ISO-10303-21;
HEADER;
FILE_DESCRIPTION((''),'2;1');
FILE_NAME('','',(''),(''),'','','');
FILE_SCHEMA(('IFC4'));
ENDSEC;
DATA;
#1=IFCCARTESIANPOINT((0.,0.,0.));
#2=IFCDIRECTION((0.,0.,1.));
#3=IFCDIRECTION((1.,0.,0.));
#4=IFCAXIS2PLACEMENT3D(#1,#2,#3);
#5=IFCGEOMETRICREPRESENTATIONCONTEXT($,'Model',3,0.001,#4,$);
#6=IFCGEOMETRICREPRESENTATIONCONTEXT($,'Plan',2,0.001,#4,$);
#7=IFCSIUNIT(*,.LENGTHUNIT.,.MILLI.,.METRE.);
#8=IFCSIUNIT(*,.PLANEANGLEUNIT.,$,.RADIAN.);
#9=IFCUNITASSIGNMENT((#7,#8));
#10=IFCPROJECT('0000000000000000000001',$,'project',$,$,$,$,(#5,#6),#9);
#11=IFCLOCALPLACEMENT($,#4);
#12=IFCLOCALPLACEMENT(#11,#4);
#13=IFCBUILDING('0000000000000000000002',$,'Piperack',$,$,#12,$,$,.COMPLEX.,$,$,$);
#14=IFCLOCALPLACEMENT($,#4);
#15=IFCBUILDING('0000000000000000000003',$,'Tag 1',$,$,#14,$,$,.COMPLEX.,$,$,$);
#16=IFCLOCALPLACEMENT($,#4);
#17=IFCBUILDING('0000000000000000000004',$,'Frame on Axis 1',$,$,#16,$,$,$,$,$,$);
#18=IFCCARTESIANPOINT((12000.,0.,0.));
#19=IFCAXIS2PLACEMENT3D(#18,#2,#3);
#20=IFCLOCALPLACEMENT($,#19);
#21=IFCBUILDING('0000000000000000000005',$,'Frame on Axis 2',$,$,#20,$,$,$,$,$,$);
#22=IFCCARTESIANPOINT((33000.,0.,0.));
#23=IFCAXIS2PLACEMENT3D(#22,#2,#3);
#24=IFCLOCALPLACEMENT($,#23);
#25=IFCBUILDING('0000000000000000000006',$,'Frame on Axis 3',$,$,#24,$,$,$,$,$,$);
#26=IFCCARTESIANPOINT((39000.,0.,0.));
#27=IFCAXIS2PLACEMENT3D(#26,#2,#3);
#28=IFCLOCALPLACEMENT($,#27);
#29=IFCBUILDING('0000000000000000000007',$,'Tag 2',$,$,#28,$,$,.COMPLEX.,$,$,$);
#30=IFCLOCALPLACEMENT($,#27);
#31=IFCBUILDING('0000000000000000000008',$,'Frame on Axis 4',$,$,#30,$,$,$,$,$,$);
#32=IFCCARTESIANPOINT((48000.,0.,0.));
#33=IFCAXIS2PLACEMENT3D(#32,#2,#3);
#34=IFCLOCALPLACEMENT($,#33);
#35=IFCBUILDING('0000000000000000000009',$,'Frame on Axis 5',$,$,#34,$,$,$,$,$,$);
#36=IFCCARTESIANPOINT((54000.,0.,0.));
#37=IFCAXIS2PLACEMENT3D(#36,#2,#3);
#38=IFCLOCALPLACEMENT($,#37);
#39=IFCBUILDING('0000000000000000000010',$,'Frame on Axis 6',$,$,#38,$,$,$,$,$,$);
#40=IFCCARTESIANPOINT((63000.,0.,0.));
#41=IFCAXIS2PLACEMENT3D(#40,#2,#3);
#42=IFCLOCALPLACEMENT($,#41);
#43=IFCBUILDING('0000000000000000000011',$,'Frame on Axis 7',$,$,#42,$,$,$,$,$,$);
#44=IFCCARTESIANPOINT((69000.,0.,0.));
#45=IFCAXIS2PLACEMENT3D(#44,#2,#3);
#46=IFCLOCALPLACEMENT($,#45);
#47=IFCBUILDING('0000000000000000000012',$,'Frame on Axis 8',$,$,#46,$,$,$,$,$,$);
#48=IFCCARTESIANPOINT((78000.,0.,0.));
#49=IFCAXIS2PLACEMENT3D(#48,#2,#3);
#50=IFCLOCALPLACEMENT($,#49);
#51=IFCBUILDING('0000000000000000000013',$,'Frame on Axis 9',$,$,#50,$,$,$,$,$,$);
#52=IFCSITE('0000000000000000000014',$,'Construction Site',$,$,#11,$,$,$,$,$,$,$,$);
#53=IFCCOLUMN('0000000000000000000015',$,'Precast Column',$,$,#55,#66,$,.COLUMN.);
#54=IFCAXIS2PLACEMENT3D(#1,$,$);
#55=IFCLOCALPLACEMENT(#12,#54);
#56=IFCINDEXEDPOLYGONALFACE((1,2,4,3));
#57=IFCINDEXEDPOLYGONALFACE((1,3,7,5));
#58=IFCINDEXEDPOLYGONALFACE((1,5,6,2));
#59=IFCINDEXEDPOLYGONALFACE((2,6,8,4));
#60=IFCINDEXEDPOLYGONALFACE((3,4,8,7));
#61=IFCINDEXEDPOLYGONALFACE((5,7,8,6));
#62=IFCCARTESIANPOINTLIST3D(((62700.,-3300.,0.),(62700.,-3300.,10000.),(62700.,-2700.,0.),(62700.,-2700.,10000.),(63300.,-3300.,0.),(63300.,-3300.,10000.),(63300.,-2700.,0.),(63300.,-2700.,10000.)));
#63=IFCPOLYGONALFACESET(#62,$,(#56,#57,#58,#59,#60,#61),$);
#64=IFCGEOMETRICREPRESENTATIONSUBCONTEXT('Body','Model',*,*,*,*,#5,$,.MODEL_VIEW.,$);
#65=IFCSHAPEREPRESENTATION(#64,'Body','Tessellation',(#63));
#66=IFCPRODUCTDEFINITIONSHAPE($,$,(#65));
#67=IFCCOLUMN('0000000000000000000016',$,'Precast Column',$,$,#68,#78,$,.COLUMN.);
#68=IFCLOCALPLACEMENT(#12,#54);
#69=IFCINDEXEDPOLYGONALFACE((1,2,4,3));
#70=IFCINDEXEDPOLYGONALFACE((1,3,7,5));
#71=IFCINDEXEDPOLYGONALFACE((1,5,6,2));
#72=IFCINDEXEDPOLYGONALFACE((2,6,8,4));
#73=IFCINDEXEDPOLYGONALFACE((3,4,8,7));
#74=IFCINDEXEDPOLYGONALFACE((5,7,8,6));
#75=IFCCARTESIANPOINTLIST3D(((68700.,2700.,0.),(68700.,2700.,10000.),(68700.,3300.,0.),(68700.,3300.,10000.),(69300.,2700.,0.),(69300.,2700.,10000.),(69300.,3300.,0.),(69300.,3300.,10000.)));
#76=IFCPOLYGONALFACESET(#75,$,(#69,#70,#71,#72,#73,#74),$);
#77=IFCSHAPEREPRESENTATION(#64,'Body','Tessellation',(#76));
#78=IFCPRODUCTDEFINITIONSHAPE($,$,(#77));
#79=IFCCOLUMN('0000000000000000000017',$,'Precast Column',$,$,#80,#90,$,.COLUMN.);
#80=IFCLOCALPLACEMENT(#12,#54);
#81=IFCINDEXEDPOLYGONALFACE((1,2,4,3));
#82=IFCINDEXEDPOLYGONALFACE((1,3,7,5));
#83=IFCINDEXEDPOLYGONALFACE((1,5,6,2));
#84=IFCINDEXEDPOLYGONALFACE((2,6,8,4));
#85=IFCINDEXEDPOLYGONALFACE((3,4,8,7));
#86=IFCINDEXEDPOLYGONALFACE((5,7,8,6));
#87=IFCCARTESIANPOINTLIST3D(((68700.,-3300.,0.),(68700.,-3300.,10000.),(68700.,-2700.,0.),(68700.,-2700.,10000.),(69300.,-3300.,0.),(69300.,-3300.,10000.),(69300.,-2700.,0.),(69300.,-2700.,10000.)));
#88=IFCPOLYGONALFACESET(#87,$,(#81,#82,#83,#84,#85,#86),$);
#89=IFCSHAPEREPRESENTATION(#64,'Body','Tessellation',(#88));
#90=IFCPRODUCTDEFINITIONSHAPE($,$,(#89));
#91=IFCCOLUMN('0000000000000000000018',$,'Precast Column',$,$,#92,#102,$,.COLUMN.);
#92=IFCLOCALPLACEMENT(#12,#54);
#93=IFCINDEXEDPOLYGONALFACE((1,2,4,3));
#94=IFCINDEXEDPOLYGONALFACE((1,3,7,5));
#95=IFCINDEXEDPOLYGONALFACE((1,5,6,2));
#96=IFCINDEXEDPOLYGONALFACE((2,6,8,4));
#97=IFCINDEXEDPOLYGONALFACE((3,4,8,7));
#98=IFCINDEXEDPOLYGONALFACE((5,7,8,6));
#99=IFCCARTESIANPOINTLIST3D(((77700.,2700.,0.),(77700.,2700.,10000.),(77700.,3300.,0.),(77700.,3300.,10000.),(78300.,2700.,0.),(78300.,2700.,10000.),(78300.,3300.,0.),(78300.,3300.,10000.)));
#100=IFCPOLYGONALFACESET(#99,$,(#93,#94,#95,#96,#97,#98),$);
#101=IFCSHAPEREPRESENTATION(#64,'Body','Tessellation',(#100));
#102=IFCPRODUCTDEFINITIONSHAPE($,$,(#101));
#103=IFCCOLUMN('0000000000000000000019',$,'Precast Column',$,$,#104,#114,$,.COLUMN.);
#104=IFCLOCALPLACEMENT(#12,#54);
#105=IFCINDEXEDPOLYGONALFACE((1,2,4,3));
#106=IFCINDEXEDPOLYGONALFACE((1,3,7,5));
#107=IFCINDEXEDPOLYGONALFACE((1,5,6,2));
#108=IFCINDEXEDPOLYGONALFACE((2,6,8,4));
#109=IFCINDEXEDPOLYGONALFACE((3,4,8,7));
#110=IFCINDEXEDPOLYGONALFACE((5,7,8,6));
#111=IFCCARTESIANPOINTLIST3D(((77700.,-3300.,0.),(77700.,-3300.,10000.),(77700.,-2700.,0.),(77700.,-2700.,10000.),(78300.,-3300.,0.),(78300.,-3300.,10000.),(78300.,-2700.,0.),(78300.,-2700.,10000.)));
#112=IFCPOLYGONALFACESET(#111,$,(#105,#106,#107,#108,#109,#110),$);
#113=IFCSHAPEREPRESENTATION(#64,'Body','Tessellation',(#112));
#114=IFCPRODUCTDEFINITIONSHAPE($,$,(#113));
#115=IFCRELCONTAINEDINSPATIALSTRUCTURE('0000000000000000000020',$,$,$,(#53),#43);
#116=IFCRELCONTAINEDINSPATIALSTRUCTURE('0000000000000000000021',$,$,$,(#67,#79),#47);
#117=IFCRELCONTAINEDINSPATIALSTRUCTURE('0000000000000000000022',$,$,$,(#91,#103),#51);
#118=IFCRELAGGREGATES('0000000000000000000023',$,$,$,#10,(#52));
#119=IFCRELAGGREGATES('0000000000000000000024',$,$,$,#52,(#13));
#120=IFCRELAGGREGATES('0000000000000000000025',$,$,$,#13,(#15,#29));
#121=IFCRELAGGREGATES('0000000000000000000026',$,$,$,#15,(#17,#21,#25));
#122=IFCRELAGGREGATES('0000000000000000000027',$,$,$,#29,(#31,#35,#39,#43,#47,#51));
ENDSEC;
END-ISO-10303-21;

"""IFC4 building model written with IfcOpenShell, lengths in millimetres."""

from ifc_helpers import new_model, si_unit, frame, origin_with_axes, place, context, subcontext, project, spatial, rectangle, extrude, element, save


model = new_model("IFC4")

# Units and contexts
model_context = context("Model", 3, precision=0.001, world=origin_with_axes())
plan_context = context("Plan", 2, precision=0.001, world=origin_with_axes())
body_context = subcontext(model_context, "Body", "Model", "MODEL_VIEW")
ifc_project = project(units=[si_unit("LENGTHUNIT", "METRE", prefix="MILLI"), si_unit("PLANEANGLEUNIT", "RADIAN")], contexts=[model_context, plan_context])

# Site, buildings
site_placement = place(None, origin_with_axes())
site = spatial("IfcSite", under=ifc_project, at=site_placement, Name="Construction Site")
building_1_placement = place(site_placement, origin_with_axes())
building_1 = spatial("IfcBuilding", under=site, at=building_1_placement, Name="Piperack", CompositionType="COMPLEX")
building_2_placement = place(None, origin_with_axes())
building_2 = spatial("IfcBuilding", under=building_1, at=building_2_placement, Name="Tag 1", CompositionType="COMPLEX")
building_3_placement = place(None, origin_with_axes())
building_3 = spatial("IfcBuilding", under=building_2, at=building_3_placement, Name="Frame on Axis 1")

# Shared definitions
building_4_placement = place(None, frame((12000.0, 0.0, 0.0), z_axis=(0.0, 0.0, 1.0), x_axis=(1.0, 0.0, 0.0)))
building_4 = spatial("IfcBuilding", under=building_2, at=building_4_placement, Name="Frame on Axis 2")

# Shared definitions
building_5_placement = place(None, frame((33000.0, 0.0, 0.0), z_axis=(0.0, 0.0, 1.0), x_axis=(1.0, 0.0, 0.0)))
building_5 = spatial("IfcBuilding", under=building_2, at=building_5_placement, Name="Frame on Axis 3")

# Shared definitions
building_6_placement = place(None, frame((39000.0, 0.0, 0.0), z_axis=(0.0, 0.0, 1.0), x_axis=(1.0, 0.0, 0.0)))
building_6 = spatial("IfcBuilding", under=building_1, at=building_6_placement, Name="Tag 2", CompositionType="COMPLEX")
building_7_placement = place(None, frame((39000.0, 0.0, 0.0), z_axis=(0.0, 0.0, 1.0), x_axis=(1.0, 0.0, 0.0)))
building_7 = spatial("IfcBuilding", under=building_6, at=building_7_placement, Name="Frame on Axis 4")

# Shared definitions
building_8_placement = place(None, frame((48000.0, 0.0, 0.0), z_axis=(0.0, 0.0, 1.0), x_axis=(1.0, 0.0, 0.0)))
building_8 = spatial("IfcBuilding", under=building_6, at=building_8_placement, Name="Frame on Axis 5")

# Shared definitions
building_9_placement = place(None, frame((54000.0, 0.0, 0.0), z_axis=(0.0, 0.0, 1.0), x_axis=(1.0, 0.0, 0.0)))
building_9 = spatial("IfcBuilding", under=building_6, at=building_9_placement, Name="Frame on Axis 6")

# Shared definitions
building_10_placement = place(None, frame((63000.0, 0.0, 0.0), z_axis=(0.0, 0.0, 1.0), x_axis=(1.0, 0.0, 0.0)))
building_10 = spatial("IfcBuilding", under=building_6, at=building_10_placement, Name="Frame on Axis 7")

# Column
for number, where, z_axis, x_axis, name in (
    (1, (0.0, -3000.0, 0.0), (0.0, 0.0, 1.0), (1.0, 0.0, 0.0), "Precast Column"),
):
    element("IfcColumn", number, at=place(building_10_placement, frame(where, z_axis=z_axis, x_axis=x_axis)), inside=building_10, Name=name, PredefinedType="COLUMN", context=body_context, shape_type="SweptSolid", body=[
        extrude(rectangle(XDim=600.0, YDim=600.0), None, (0.0, 0.0, 1.0), 10000.0),
    ])

# Shared definitions
building_11_placement = place(None, frame((69000.0, 0.0, 0.0), z_axis=(0.0, 0.0, 1.0), x_axis=(1.0, 0.0, 0.0)))
building_11 = spatial("IfcBuilding", under=building_6, at=building_11_placement, Name="Frame on Axis 8")

# Columns
for number, where, z_axis, x_axis, name in (
    (2, (0.0, 3000.0, 0.0), (0.0, 0.0, 1.0), (1.0, 0.0, 0.0), "Precast Column"),
    (3, (0.0, -3000.0, 0.0), (0.0, 0.0, 1.0), (1.0, 0.0, 0.0), "Precast Column"),
):
    element("IfcColumn", number, at=place(building_11_placement, frame(where, z_axis=z_axis, x_axis=x_axis)), inside=building_11, Name=name, PredefinedType="COLUMN", context=body_context, shape_type="SweptSolid", body=[
        extrude(rectangle(XDim=600.0, YDim=600.0), None, (0.0, 0.0, 1.0), 10000.0),
    ])

# Shared definitions
building_12_placement = place(None, frame((78000.0, 0.0, 0.0), z_axis=(0.0, 0.0, 1.0), x_axis=(1.0, 0.0, 0.0)))
building_12 = spatial("IfcBuilding", under=building_6, at=building_12_placement, Name="Frame on Axis 9")

# Columns
for number, where, z_axis, x_axis, name in (
    (4, (0.0, 3000.0, 0.0), (0.0, 0.0, 1.0), (1.0, 0.0, 0.0), "Precast Column"),
    (5, (0.0, -3000.0, 0.0), (0.0, 0.0, 1.0), (1.0, 0.0, 0.0), "Precast Column"),
):
    element("IfcColumn", number, at=place(building_12_placement, frame(where, z_axis=z_axis, x_axis=x_axis)), inside=building_12, Name=name, PredefinedType="COLUMN", context=body_context, shape_type="SweptSolid", body=[
        extrude(rectangle(XDim=600.0, YDim=600.0), None, (0.0, 0.0, 1.0), 10000.0),
    ])

save(model, "model.ifc")
